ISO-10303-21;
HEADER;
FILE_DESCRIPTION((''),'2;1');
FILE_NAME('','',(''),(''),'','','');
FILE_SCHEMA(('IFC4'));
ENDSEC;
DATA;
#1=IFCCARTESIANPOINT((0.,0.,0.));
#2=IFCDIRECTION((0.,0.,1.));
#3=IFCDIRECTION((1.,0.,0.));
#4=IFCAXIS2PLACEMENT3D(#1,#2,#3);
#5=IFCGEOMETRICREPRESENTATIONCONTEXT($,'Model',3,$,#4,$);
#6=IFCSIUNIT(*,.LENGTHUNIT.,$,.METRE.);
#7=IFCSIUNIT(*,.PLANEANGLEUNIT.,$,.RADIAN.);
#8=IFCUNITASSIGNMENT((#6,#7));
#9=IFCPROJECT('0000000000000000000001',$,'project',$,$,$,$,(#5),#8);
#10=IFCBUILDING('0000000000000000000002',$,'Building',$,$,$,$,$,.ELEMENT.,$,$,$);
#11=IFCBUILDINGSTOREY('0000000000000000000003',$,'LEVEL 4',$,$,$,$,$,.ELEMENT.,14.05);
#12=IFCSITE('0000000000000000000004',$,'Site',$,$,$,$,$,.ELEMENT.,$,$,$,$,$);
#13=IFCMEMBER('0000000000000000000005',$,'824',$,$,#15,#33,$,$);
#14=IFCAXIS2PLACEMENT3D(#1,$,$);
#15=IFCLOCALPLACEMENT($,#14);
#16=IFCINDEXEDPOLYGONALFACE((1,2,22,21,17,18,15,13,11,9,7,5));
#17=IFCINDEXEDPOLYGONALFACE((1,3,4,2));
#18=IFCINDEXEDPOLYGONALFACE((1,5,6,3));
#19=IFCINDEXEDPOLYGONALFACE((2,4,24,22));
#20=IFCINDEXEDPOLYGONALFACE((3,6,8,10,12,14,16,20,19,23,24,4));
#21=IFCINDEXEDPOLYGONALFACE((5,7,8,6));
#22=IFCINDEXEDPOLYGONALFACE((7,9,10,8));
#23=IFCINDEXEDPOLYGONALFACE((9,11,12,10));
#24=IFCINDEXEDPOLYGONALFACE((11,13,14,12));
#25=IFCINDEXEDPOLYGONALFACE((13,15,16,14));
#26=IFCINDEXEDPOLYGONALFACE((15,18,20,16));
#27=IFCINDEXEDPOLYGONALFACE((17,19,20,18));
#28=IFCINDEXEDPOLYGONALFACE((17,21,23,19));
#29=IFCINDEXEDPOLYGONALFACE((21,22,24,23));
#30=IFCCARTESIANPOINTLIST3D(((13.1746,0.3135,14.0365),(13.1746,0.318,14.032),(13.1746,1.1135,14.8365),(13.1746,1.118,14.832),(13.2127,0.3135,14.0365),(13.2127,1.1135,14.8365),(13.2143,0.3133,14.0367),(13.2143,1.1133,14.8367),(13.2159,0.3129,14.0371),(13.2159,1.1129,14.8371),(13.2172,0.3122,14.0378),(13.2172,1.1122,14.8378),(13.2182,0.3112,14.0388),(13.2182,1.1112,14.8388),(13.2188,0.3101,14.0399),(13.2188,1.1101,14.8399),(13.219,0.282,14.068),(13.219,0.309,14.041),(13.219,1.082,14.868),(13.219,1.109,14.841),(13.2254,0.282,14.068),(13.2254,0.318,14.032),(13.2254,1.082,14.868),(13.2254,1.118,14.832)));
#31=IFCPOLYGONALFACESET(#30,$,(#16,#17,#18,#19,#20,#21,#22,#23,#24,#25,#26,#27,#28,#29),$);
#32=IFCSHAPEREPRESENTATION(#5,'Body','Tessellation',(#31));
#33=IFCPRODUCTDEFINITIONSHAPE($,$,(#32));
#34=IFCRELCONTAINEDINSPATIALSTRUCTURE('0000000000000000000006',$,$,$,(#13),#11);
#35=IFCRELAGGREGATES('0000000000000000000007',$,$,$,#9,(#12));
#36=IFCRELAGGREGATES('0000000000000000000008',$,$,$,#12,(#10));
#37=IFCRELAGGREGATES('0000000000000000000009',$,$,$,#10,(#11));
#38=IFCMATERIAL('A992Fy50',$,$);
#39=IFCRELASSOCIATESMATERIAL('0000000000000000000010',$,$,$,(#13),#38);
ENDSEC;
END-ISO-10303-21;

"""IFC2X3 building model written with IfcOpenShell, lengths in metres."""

from ifc_helpers import new_model, si_unit, frame, origin_with_axes, origin_2d_with_axis, place, context, project, spatial, l_section, extrude, material, element, save


model = new_model("IFC2X3")

# Units and contexts
model_context = context("Model", 3, world=origin_with_axes())
ifc_project = project(units=[si_unit("LENGTHUNIT", "METRE"), si_unit("PLANEANGLEUNIT", "RADIAN")], contexts=[model_context])

# Site, building, storey
site = spatial("IfcSite", under=ifc_project, Name="Site", CompositionType="ELEMENT")
building = spatial("IfcBuilding", under=site, Name="Building", CompositionType="ELEMENT")
storey = spatial("IfcBuildingStorey", under=building, Name="LEVEL 4", CompositionType="ELEMENT", Elevation=14.05)

# Shared definitions
ifc_material = material(Name="A992Fy50")

# Member
for number, where, z_axis, x_axis, name in (
    (1, (13.2, 0.3, 14.05), (0.0, 0.707107, 0.707107), (-1.0, 0.0, 0.0), "824"),
):
    element("IfcMember", number, at=place(None, frame(where, z_axis=z_axis, x_axis=x_axis)), inside=storey, material=ifc_material, Name=name, context=model_context, shape_type="SweptSolid", body=[
        extrude(l_section(Depth=0.0508, Width=0.0508, Thickness=0.0063, FilletRadius=0.0063, at=origin_2d_with_axis()), origin_with_axes(), (0.0, 0.0, 1.0), 1.1314),
    ])

save(model, "model.ifc")
